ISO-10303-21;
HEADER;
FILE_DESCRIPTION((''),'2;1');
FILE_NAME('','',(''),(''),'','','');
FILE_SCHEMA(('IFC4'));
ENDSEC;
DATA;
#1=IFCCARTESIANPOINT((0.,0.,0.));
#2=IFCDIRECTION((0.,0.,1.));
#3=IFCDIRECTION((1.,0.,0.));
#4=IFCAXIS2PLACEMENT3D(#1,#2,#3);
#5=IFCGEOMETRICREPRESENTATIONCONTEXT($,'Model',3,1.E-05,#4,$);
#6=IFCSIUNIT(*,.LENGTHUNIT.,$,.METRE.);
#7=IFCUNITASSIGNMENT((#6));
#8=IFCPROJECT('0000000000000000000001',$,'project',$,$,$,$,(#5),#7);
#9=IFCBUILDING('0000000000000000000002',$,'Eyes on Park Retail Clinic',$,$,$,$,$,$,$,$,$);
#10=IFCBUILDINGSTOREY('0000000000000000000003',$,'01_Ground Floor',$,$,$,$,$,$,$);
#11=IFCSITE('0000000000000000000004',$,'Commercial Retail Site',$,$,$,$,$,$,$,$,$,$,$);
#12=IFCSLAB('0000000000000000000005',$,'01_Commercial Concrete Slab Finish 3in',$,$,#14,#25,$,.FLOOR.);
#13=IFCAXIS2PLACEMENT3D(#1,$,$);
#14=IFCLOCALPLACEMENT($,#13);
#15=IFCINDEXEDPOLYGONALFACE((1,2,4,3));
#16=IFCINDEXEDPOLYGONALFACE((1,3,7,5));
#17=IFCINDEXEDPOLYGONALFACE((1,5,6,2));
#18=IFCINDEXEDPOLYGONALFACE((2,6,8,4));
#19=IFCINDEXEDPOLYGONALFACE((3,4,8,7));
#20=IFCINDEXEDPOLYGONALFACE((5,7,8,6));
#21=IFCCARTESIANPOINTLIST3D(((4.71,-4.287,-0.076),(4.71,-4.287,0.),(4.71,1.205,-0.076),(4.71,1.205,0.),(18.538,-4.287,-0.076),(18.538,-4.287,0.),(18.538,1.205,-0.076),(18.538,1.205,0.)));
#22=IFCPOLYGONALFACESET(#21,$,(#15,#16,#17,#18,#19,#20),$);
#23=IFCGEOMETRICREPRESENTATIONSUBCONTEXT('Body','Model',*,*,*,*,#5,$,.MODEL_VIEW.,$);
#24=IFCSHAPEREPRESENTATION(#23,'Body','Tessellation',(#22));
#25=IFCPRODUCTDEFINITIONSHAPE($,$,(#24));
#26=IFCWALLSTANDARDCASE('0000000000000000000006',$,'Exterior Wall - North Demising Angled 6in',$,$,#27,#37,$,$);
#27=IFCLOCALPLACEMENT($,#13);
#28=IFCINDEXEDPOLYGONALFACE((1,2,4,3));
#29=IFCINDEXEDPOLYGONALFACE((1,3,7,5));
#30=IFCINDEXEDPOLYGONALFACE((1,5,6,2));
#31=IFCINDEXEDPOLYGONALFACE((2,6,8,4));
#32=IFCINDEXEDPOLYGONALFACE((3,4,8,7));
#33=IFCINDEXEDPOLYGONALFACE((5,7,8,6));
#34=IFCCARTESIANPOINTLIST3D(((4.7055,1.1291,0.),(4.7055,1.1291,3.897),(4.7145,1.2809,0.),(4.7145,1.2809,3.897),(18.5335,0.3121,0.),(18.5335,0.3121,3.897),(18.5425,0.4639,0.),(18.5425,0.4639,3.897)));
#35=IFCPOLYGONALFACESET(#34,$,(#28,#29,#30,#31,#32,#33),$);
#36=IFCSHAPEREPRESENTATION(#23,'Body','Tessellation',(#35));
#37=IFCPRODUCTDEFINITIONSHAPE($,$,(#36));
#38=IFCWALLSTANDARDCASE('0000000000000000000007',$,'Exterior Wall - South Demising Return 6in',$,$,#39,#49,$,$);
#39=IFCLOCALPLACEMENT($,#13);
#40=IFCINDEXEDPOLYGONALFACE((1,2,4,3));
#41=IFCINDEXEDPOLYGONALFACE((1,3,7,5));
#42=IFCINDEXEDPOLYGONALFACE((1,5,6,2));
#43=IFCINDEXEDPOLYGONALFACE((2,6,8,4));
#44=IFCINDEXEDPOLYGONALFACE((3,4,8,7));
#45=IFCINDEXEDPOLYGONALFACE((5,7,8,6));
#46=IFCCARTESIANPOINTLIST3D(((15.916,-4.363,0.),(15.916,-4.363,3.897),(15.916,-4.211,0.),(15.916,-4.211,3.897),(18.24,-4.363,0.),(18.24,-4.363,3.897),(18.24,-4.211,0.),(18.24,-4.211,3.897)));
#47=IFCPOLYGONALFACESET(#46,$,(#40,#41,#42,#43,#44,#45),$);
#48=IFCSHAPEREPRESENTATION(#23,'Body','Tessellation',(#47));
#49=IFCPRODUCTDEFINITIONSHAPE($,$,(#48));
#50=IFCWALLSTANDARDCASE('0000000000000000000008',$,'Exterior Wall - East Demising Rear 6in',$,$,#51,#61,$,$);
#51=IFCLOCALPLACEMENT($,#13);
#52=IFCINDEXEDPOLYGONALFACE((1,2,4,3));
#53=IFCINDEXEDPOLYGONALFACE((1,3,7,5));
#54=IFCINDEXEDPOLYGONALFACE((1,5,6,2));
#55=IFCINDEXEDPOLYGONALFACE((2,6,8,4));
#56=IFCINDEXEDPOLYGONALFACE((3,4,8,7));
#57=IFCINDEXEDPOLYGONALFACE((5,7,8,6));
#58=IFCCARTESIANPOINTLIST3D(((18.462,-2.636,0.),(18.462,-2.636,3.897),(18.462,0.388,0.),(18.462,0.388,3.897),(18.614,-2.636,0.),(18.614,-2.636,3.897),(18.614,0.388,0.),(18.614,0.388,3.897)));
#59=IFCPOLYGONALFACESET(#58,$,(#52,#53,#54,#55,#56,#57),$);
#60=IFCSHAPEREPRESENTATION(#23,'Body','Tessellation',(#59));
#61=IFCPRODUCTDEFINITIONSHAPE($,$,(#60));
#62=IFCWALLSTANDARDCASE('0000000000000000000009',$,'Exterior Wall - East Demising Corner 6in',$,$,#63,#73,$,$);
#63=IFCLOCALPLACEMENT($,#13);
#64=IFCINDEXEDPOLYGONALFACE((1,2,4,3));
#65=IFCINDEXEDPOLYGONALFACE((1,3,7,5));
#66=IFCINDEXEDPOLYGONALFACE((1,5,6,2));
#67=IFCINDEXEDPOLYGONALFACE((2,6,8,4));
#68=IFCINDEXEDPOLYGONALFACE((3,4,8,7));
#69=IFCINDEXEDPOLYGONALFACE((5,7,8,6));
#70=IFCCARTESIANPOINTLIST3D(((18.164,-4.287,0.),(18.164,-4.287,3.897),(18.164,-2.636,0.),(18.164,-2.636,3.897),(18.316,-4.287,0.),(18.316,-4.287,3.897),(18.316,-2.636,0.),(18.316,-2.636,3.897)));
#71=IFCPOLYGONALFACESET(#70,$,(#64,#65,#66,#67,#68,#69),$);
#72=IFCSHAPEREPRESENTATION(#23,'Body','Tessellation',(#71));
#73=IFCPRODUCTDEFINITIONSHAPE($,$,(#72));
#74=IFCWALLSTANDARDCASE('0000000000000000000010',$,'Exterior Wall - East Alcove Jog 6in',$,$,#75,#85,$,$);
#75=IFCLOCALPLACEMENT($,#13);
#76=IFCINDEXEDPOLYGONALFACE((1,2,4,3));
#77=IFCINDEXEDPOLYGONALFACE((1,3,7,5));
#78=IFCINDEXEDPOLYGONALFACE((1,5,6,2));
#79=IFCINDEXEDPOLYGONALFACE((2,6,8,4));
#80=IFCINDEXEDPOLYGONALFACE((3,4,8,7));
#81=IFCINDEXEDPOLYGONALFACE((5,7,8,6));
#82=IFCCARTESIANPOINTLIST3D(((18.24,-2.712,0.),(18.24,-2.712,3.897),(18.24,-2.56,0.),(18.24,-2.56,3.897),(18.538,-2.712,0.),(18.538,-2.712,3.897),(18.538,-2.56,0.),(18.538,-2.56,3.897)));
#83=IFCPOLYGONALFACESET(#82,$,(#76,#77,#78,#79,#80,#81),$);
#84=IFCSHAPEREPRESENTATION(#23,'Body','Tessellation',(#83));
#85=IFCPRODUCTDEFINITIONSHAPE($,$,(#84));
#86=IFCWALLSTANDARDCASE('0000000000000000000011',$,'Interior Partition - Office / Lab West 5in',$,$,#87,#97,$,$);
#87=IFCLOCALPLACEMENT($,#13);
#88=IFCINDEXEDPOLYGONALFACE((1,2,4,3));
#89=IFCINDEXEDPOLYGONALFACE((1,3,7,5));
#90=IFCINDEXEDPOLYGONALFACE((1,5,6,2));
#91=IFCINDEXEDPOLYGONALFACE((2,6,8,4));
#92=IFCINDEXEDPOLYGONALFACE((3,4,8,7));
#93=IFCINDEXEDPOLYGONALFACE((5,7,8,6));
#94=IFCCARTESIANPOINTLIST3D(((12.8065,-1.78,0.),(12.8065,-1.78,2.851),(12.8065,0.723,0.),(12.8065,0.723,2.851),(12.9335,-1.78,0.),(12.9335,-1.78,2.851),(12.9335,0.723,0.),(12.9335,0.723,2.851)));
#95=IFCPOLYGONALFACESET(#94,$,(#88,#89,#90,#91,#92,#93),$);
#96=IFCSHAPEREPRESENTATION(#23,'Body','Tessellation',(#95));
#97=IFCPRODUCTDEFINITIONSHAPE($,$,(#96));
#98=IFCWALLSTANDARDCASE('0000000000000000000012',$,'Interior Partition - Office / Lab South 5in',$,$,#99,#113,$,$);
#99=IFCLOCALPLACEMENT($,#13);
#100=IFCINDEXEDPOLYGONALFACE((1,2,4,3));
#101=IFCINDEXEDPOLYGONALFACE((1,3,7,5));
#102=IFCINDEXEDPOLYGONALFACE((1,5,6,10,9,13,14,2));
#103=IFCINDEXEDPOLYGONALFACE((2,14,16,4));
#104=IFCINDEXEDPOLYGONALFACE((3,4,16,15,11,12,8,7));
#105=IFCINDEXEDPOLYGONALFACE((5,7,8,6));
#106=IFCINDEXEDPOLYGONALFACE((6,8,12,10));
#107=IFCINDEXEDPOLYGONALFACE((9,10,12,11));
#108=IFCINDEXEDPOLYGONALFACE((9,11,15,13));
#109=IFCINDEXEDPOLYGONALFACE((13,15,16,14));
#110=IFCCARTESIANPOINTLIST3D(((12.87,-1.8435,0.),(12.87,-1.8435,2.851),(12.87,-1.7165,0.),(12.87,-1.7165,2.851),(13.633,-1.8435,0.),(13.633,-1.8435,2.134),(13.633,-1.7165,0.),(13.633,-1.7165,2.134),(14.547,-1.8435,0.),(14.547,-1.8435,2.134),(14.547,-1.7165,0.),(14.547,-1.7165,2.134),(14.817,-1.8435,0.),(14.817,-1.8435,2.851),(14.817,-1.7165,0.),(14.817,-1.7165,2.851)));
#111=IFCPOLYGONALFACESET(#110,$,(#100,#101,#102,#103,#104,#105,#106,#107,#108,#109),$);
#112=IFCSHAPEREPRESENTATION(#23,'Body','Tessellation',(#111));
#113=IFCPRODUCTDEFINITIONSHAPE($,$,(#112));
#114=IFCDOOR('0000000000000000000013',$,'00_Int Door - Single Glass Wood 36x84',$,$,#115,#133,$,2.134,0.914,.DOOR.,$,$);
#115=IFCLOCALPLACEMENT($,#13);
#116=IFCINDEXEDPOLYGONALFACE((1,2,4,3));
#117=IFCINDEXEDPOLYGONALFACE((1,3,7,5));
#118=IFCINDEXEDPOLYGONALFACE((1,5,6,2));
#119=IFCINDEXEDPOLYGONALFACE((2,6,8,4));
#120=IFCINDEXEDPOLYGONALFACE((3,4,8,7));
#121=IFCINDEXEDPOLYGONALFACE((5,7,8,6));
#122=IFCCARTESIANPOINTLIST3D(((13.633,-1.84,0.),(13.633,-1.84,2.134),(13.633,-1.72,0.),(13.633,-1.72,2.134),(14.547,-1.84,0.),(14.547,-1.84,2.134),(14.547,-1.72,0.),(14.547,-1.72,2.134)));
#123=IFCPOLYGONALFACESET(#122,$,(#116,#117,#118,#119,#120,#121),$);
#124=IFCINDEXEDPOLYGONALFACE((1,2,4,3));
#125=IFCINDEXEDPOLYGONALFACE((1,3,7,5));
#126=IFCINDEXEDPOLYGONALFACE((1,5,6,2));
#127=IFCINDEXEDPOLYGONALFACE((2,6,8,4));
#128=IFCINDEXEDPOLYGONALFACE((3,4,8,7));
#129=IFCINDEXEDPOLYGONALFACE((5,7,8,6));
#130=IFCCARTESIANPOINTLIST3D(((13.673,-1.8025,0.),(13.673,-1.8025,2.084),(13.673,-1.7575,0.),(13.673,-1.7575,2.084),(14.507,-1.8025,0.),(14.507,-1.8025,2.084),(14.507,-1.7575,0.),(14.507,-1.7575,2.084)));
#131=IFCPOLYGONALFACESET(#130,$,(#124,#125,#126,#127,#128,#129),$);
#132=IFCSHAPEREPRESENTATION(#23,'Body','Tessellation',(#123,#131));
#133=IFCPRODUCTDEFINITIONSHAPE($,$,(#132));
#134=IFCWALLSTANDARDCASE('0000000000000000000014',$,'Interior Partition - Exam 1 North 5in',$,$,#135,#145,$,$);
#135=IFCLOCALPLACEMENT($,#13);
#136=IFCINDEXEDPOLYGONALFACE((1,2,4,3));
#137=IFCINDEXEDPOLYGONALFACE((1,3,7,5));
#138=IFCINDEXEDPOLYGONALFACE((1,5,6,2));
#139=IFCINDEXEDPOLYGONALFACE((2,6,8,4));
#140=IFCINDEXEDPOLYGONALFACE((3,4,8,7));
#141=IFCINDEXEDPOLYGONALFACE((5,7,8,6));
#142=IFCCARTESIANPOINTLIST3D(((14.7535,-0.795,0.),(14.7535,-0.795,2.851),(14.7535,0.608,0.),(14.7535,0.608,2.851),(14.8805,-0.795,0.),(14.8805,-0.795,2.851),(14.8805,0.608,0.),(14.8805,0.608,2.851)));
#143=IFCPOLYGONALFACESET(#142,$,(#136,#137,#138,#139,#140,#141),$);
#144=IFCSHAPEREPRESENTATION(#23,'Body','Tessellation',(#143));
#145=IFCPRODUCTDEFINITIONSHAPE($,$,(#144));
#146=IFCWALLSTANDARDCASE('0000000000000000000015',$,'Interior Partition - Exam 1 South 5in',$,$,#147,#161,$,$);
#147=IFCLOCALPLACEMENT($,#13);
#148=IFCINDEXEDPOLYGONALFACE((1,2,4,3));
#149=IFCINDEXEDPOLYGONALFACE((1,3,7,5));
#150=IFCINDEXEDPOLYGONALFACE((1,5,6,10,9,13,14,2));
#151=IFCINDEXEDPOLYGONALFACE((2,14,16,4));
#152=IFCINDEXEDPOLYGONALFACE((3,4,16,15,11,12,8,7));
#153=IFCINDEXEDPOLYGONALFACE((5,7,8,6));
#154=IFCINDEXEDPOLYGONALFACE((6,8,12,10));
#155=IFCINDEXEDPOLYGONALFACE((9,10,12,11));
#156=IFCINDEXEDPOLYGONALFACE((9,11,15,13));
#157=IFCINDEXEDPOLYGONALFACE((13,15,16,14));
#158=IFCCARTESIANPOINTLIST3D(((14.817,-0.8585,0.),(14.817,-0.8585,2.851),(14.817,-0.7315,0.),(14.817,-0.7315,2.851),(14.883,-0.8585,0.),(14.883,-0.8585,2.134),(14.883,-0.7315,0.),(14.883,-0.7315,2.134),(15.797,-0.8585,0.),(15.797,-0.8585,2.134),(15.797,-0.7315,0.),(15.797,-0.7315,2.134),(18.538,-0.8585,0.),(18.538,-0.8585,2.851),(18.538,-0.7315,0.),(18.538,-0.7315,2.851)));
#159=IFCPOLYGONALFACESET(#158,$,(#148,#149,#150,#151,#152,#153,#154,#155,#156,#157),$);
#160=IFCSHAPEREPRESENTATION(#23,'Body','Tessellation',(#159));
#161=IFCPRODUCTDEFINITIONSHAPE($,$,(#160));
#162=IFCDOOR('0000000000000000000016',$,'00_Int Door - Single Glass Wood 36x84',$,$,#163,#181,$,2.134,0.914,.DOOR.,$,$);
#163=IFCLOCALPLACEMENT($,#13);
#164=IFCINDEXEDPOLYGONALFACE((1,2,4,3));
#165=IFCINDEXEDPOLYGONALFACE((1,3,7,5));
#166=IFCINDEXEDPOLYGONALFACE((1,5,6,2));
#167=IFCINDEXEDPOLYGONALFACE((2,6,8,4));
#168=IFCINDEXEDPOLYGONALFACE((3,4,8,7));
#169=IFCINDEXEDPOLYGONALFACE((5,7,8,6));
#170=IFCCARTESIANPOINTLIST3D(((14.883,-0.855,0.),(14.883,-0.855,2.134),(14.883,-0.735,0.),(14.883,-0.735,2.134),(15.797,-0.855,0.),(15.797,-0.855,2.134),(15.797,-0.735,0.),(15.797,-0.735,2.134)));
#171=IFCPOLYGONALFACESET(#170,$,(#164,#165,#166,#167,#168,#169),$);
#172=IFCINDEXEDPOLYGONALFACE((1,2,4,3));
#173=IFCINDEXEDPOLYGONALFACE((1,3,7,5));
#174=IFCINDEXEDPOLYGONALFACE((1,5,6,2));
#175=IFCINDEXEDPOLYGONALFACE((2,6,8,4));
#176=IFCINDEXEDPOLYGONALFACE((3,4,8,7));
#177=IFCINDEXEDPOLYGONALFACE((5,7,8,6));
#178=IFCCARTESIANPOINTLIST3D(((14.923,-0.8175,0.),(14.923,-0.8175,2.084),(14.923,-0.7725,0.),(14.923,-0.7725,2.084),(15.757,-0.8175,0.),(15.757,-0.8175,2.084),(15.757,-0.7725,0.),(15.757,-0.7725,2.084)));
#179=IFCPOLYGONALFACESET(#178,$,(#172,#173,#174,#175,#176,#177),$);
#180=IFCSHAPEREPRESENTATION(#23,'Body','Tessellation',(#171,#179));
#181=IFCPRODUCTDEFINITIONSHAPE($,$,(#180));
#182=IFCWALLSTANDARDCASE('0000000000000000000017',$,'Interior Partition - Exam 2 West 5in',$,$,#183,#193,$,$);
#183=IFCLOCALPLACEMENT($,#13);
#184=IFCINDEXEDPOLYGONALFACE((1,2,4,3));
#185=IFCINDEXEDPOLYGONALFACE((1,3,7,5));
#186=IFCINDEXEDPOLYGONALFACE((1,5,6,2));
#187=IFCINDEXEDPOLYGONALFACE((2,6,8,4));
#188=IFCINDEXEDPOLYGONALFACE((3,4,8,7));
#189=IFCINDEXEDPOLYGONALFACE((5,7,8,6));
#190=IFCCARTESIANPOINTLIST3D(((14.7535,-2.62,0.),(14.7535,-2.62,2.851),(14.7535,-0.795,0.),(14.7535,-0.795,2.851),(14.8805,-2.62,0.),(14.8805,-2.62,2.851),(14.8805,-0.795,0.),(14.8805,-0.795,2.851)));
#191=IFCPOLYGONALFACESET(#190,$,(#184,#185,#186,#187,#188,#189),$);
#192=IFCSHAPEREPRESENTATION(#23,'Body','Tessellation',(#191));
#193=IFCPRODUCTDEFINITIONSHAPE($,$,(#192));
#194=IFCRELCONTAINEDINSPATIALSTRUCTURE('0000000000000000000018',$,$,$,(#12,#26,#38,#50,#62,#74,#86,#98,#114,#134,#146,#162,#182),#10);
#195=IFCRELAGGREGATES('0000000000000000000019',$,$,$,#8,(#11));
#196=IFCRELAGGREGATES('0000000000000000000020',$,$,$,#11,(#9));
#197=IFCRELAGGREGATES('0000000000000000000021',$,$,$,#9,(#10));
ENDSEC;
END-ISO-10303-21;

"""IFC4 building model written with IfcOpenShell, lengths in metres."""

from ifc_helpers import new_model, si_unit, frame, origin, origin_with_axes, place, context, subcontext, project, spatial, rectangle, extrude, element, fill, save


model = new_model("IFC4")

# Units and contexts
model_context = context("Model", 3, precision=1e-05, world=origin_with_axes())
body_context = subcontext(model_context, "Body", "Model", "MODEL_VIEW")
ifc_project = project(units=[si_unit("LENGTHUNIT", "METRE")], contexts=[model_context])

# Site, building, storey
site = spatial("IfcSite", under=ifc_project, Name="Commercial Retail Site")
building = spatial("IfcBuilding", under=site, Name="Eyes on Park Retail Clinic")
storey = spatial("IfcBuildingStorey", under=building, Name="01_Ground Floor")

# Slab
slab_placement = place(None, frame((11.624, -1.541, -0.076), z_axis=(0.0, 0.0, 1.0), x_axis=(1.0, 0.0, 0.0)))
element("IfcSlab", 1, at=slab_placement, inside=storey, Name="01_Commercial Concrete Slab Finish 3in", PredefinedType="FLOOR", context=body_context, shape_type="SweptSolid", body=[
    extrude(rectangle(XDim=13.828, YDim=5.492), origin(), (0.0, 0.0, 1.0), 0.076),
])

# Walls
wall_1_placement = place(None, frame((11.624, 0.7965, 0.0), z_axis=(0.0, 0.0, 1.0), x_axis=(0.998259, -0.05898, 0.0)))
element("IfcWallStandardCase", 2, at=wall_1_placement, inside=storey, Name="Exterior Wall - North Demising Angled 6in", context=body_context, shape_type="SweptSolid", body=[
    extrude(rectangle(XDim=13.8521, YDim=0.152), origin(), (0.0, 0.0, 1.0), 3.897),
])
wall_2_placement = place(None, frame((17.078, -4.287, 0.0), z_axis=(0.0, 0.0, 1.0), x_axis=(1.0, 0.0, 0.0)))
element("IfcWallStandardCase", 3, at=wall_2_placement, inside=storey, Name="Exterior Wall - South Demising Return 6in", context=body_context, shape_type="SweptSolid", body=[
    extrude(rectangle(XDim=2.324, YDim=0.152), origin(), (0.0, 0.0, 1.0), 3.897),
])
wall_3_placement = place(None, frame((18.538, -1.124, 0.0), z_axis=(0.0, 0.0, 1.0), x_axis=(0.0, -1.0, 0.0)))
element("IfcWallStandardCase", 4, at=wall_3_placement, inside=storey, Name="Exterior Wall - East Demising Rear 6in", context=body_context, shape_type="SweptSolid", body=[
    extrude(rectangle(XDim=3.024, YDim=0.152), origin(), (0.0, 0.0, 1.0), 3.897),
])
wall_4_placement = place(None, frame((18.24, -3.4615, 0.0), z_axis=(0.0, 0.0, 1.0), x_axis=(0.0, -1.0, 0.0)))
element("IfcWallStandardCase", 5, at=wall_4_placement, inside=storey, Name="Exterior Wall - East Demising Corner 6in", context=body_context, shape_type="SweptSolid", body=[
    extrude(rectangle(XDim=1.651, YDim=0.152), origin(), (0.0, 0.0, 1.0), 3.897),
])
wall_5_placement = place(None, frame((18.389, -2.636, 0.0), z_axis=(0.0, 0.0, 1.0), x_axis=(-1.0, 0.0, 0.0)))
element("IfcWallStandardCase", 6, at=wall_5_placement, inside=storey, Name="Exterior Wall - East Alcove Jog 6in", context=body_context, shape_type="SweptSolid", body=[
    extrude(rectangle(XDim=0.298, YDim=0.152), origin(), (0.0, 0.0, 1.0), 3.897),
])
wall_6_placement = place(None, frame((12.87, -0.5285, 0.0), z_axis=(0.0, 0.0, 1.0), x_axis=(0.0, -1.0, 0.0)))
element("IfcWallStandardCase", 7, at=wall_6_placement, inside=storey, Name="Interior Partition - Office / Lab West 5in", context=body_context, shape_type="SweptSolid", body=[
    extrude(rectangle(XDim=2.503, YDim=0.127), origin(), (0.0, 0.0, 1.0), 2.851),
])

# Wall, opening, door
wall_7_placement = place(None, frame((13.8435, -1.78, 0.0), z_axis=(0.0, 0.0, 1.0), x_axis=(1.0, 0.0, 0.0)))
wall_7 = element("IfcWallStandardCase", 8, at=wall_7_placement, inside=storey, Name="Interior Partition - Office / Lab South 5in", context=body_context, shape_type="SweptSolid", body=[
    extrude(rectangle(XDim=1.947, YDim=0.127), origin(), (0.0, 0.0, 1.0), 2.851),
])
opening_1_placement = place(None, frame((14.09, -1.78, 0.0), z_axis=(0.0, 0.0, 1.0), x_axis=(1.0, 0.0, 0.0)))
opening_1 = element("IfcOpeningElement", 9, at=opening_1_placement, cuts=wall_7, context=body_context, shape_type="SweptSolid", body=[
    extrude(rectangle(XDim=0.914, YDim=0.227), origin(), (0.0, 0.0, 1.0), 2.134),
])
door_1_placement = place(opening_1_placement, origin_with_axes())
door_1 = element("IfcDoor", 10, at=door_1_placement, inside=storey, Name="00_Int Door - Single Glass Wood 36x84", OverallHeight=2.134, OverallWidth=0.914, PredefinedType="DOOR", context=body_context, shape_type="SweptSolid", body=[
    extrude(rectangle(XDim=0.914, YDim=0.12), origin(), (0.0, 0.0, 1.0), 2.134),
    extrude(rectangle(XDim=0.834, YDim=0.045), origin(), (0.0, 0.0, 1.0), 2.084),
])
fill(opening_1, door_1)

# Wall
wall_8_placement = place(None, frame((14.817, -0.0935, 0.0), z_axis=(0.0, 0.0, 1.0), x_axis=(0.0, -1.0, 0.0)))
element("IfcWallStandardCase", 11, at=wall_8_placement, inside=storey, Name="Interior Partition - Exam 1 North 5in", context=body_context, shape_type="SweptSolid", body=[
    extrude(rectangle(XDim=1.403, YDim=0.127), origin(), (0.0, 0.0, 1.0), 2.851),
])

# Wall, opening, door
wall_9_placement = place(None, frame((16.6775, -0.795, 0.0), z_axis=(0.0, 0.0, 1.0), x_axis=(1.0, 0.0, 0.0)))
wall_9 = element("IfcWallStandardCase", 12, at=wall_9_placement, inside=storey, Name="Interior Partition - Exam 1 South 5in", context=body_context, shape_type="SweptSolid", body=[
    extrude(rectangle(XDim=3.721, YDim=0.127), origin(), (0.0, 0.0, 1.0), 2.851),
])
opening_2_placement = place(None, frame((15.34, -0.795, 0.0), z_axis=(0.0, 0.0, 1.0), x_axis=(1.0, 0.0, 0.0)))
opening_2 = element("IfcOpeningElement", 13, at=opening_2_placement, cuts=wall_9, context=body_context, shape_type="SweptSolid", body=[
    extrude(rectangle(XDim=0.914, YDim=0.227), origin(), (0.0, 0.0, 1.0), 2.134),
])
door_2_placement = place(opening_2_placement, origin_with_axes())
door_2 = element("IfcDoor", 14, at=door_2_placement, inside=storey, Name="00_Int Door - Single Glass Wood 36x84", OverallHeight=2.134, OverallWidth=0.914, PredefinedType="DOOR", context=body_context, shape_type="SweptSolid", body=[
    extrude(rectangle(XDim=0.914, YDim=0.12), origin(), (0.0, 0.0, 1.0), 2.134),
    extrude(rectangle(XDim=0.834, YDim=0.045), origin(), (0.0, 0.0, 1.0), 2.084),
])
fill(opening_2, door_2)

# Wall
wall_10_placement = place(None, frame((14.817, -1.7075, 0.0), z_axis=(0.0, 0.0, 1.0), x_axis=(0.0, -1.0, 0.0)))
element("IfcWallStandardCase", 15, at=wall_10_placement, inside=storey, Name="Interior Partition - Exam 2 West 5in", context=body_context, shape_type="SweptSolid", body=[
    extrude(rectangle(XDim=1.825, YDim=0.127), origin(), (0.0, 0.0, 1.0), 2.851),
])

save(model, "model.ifc")
